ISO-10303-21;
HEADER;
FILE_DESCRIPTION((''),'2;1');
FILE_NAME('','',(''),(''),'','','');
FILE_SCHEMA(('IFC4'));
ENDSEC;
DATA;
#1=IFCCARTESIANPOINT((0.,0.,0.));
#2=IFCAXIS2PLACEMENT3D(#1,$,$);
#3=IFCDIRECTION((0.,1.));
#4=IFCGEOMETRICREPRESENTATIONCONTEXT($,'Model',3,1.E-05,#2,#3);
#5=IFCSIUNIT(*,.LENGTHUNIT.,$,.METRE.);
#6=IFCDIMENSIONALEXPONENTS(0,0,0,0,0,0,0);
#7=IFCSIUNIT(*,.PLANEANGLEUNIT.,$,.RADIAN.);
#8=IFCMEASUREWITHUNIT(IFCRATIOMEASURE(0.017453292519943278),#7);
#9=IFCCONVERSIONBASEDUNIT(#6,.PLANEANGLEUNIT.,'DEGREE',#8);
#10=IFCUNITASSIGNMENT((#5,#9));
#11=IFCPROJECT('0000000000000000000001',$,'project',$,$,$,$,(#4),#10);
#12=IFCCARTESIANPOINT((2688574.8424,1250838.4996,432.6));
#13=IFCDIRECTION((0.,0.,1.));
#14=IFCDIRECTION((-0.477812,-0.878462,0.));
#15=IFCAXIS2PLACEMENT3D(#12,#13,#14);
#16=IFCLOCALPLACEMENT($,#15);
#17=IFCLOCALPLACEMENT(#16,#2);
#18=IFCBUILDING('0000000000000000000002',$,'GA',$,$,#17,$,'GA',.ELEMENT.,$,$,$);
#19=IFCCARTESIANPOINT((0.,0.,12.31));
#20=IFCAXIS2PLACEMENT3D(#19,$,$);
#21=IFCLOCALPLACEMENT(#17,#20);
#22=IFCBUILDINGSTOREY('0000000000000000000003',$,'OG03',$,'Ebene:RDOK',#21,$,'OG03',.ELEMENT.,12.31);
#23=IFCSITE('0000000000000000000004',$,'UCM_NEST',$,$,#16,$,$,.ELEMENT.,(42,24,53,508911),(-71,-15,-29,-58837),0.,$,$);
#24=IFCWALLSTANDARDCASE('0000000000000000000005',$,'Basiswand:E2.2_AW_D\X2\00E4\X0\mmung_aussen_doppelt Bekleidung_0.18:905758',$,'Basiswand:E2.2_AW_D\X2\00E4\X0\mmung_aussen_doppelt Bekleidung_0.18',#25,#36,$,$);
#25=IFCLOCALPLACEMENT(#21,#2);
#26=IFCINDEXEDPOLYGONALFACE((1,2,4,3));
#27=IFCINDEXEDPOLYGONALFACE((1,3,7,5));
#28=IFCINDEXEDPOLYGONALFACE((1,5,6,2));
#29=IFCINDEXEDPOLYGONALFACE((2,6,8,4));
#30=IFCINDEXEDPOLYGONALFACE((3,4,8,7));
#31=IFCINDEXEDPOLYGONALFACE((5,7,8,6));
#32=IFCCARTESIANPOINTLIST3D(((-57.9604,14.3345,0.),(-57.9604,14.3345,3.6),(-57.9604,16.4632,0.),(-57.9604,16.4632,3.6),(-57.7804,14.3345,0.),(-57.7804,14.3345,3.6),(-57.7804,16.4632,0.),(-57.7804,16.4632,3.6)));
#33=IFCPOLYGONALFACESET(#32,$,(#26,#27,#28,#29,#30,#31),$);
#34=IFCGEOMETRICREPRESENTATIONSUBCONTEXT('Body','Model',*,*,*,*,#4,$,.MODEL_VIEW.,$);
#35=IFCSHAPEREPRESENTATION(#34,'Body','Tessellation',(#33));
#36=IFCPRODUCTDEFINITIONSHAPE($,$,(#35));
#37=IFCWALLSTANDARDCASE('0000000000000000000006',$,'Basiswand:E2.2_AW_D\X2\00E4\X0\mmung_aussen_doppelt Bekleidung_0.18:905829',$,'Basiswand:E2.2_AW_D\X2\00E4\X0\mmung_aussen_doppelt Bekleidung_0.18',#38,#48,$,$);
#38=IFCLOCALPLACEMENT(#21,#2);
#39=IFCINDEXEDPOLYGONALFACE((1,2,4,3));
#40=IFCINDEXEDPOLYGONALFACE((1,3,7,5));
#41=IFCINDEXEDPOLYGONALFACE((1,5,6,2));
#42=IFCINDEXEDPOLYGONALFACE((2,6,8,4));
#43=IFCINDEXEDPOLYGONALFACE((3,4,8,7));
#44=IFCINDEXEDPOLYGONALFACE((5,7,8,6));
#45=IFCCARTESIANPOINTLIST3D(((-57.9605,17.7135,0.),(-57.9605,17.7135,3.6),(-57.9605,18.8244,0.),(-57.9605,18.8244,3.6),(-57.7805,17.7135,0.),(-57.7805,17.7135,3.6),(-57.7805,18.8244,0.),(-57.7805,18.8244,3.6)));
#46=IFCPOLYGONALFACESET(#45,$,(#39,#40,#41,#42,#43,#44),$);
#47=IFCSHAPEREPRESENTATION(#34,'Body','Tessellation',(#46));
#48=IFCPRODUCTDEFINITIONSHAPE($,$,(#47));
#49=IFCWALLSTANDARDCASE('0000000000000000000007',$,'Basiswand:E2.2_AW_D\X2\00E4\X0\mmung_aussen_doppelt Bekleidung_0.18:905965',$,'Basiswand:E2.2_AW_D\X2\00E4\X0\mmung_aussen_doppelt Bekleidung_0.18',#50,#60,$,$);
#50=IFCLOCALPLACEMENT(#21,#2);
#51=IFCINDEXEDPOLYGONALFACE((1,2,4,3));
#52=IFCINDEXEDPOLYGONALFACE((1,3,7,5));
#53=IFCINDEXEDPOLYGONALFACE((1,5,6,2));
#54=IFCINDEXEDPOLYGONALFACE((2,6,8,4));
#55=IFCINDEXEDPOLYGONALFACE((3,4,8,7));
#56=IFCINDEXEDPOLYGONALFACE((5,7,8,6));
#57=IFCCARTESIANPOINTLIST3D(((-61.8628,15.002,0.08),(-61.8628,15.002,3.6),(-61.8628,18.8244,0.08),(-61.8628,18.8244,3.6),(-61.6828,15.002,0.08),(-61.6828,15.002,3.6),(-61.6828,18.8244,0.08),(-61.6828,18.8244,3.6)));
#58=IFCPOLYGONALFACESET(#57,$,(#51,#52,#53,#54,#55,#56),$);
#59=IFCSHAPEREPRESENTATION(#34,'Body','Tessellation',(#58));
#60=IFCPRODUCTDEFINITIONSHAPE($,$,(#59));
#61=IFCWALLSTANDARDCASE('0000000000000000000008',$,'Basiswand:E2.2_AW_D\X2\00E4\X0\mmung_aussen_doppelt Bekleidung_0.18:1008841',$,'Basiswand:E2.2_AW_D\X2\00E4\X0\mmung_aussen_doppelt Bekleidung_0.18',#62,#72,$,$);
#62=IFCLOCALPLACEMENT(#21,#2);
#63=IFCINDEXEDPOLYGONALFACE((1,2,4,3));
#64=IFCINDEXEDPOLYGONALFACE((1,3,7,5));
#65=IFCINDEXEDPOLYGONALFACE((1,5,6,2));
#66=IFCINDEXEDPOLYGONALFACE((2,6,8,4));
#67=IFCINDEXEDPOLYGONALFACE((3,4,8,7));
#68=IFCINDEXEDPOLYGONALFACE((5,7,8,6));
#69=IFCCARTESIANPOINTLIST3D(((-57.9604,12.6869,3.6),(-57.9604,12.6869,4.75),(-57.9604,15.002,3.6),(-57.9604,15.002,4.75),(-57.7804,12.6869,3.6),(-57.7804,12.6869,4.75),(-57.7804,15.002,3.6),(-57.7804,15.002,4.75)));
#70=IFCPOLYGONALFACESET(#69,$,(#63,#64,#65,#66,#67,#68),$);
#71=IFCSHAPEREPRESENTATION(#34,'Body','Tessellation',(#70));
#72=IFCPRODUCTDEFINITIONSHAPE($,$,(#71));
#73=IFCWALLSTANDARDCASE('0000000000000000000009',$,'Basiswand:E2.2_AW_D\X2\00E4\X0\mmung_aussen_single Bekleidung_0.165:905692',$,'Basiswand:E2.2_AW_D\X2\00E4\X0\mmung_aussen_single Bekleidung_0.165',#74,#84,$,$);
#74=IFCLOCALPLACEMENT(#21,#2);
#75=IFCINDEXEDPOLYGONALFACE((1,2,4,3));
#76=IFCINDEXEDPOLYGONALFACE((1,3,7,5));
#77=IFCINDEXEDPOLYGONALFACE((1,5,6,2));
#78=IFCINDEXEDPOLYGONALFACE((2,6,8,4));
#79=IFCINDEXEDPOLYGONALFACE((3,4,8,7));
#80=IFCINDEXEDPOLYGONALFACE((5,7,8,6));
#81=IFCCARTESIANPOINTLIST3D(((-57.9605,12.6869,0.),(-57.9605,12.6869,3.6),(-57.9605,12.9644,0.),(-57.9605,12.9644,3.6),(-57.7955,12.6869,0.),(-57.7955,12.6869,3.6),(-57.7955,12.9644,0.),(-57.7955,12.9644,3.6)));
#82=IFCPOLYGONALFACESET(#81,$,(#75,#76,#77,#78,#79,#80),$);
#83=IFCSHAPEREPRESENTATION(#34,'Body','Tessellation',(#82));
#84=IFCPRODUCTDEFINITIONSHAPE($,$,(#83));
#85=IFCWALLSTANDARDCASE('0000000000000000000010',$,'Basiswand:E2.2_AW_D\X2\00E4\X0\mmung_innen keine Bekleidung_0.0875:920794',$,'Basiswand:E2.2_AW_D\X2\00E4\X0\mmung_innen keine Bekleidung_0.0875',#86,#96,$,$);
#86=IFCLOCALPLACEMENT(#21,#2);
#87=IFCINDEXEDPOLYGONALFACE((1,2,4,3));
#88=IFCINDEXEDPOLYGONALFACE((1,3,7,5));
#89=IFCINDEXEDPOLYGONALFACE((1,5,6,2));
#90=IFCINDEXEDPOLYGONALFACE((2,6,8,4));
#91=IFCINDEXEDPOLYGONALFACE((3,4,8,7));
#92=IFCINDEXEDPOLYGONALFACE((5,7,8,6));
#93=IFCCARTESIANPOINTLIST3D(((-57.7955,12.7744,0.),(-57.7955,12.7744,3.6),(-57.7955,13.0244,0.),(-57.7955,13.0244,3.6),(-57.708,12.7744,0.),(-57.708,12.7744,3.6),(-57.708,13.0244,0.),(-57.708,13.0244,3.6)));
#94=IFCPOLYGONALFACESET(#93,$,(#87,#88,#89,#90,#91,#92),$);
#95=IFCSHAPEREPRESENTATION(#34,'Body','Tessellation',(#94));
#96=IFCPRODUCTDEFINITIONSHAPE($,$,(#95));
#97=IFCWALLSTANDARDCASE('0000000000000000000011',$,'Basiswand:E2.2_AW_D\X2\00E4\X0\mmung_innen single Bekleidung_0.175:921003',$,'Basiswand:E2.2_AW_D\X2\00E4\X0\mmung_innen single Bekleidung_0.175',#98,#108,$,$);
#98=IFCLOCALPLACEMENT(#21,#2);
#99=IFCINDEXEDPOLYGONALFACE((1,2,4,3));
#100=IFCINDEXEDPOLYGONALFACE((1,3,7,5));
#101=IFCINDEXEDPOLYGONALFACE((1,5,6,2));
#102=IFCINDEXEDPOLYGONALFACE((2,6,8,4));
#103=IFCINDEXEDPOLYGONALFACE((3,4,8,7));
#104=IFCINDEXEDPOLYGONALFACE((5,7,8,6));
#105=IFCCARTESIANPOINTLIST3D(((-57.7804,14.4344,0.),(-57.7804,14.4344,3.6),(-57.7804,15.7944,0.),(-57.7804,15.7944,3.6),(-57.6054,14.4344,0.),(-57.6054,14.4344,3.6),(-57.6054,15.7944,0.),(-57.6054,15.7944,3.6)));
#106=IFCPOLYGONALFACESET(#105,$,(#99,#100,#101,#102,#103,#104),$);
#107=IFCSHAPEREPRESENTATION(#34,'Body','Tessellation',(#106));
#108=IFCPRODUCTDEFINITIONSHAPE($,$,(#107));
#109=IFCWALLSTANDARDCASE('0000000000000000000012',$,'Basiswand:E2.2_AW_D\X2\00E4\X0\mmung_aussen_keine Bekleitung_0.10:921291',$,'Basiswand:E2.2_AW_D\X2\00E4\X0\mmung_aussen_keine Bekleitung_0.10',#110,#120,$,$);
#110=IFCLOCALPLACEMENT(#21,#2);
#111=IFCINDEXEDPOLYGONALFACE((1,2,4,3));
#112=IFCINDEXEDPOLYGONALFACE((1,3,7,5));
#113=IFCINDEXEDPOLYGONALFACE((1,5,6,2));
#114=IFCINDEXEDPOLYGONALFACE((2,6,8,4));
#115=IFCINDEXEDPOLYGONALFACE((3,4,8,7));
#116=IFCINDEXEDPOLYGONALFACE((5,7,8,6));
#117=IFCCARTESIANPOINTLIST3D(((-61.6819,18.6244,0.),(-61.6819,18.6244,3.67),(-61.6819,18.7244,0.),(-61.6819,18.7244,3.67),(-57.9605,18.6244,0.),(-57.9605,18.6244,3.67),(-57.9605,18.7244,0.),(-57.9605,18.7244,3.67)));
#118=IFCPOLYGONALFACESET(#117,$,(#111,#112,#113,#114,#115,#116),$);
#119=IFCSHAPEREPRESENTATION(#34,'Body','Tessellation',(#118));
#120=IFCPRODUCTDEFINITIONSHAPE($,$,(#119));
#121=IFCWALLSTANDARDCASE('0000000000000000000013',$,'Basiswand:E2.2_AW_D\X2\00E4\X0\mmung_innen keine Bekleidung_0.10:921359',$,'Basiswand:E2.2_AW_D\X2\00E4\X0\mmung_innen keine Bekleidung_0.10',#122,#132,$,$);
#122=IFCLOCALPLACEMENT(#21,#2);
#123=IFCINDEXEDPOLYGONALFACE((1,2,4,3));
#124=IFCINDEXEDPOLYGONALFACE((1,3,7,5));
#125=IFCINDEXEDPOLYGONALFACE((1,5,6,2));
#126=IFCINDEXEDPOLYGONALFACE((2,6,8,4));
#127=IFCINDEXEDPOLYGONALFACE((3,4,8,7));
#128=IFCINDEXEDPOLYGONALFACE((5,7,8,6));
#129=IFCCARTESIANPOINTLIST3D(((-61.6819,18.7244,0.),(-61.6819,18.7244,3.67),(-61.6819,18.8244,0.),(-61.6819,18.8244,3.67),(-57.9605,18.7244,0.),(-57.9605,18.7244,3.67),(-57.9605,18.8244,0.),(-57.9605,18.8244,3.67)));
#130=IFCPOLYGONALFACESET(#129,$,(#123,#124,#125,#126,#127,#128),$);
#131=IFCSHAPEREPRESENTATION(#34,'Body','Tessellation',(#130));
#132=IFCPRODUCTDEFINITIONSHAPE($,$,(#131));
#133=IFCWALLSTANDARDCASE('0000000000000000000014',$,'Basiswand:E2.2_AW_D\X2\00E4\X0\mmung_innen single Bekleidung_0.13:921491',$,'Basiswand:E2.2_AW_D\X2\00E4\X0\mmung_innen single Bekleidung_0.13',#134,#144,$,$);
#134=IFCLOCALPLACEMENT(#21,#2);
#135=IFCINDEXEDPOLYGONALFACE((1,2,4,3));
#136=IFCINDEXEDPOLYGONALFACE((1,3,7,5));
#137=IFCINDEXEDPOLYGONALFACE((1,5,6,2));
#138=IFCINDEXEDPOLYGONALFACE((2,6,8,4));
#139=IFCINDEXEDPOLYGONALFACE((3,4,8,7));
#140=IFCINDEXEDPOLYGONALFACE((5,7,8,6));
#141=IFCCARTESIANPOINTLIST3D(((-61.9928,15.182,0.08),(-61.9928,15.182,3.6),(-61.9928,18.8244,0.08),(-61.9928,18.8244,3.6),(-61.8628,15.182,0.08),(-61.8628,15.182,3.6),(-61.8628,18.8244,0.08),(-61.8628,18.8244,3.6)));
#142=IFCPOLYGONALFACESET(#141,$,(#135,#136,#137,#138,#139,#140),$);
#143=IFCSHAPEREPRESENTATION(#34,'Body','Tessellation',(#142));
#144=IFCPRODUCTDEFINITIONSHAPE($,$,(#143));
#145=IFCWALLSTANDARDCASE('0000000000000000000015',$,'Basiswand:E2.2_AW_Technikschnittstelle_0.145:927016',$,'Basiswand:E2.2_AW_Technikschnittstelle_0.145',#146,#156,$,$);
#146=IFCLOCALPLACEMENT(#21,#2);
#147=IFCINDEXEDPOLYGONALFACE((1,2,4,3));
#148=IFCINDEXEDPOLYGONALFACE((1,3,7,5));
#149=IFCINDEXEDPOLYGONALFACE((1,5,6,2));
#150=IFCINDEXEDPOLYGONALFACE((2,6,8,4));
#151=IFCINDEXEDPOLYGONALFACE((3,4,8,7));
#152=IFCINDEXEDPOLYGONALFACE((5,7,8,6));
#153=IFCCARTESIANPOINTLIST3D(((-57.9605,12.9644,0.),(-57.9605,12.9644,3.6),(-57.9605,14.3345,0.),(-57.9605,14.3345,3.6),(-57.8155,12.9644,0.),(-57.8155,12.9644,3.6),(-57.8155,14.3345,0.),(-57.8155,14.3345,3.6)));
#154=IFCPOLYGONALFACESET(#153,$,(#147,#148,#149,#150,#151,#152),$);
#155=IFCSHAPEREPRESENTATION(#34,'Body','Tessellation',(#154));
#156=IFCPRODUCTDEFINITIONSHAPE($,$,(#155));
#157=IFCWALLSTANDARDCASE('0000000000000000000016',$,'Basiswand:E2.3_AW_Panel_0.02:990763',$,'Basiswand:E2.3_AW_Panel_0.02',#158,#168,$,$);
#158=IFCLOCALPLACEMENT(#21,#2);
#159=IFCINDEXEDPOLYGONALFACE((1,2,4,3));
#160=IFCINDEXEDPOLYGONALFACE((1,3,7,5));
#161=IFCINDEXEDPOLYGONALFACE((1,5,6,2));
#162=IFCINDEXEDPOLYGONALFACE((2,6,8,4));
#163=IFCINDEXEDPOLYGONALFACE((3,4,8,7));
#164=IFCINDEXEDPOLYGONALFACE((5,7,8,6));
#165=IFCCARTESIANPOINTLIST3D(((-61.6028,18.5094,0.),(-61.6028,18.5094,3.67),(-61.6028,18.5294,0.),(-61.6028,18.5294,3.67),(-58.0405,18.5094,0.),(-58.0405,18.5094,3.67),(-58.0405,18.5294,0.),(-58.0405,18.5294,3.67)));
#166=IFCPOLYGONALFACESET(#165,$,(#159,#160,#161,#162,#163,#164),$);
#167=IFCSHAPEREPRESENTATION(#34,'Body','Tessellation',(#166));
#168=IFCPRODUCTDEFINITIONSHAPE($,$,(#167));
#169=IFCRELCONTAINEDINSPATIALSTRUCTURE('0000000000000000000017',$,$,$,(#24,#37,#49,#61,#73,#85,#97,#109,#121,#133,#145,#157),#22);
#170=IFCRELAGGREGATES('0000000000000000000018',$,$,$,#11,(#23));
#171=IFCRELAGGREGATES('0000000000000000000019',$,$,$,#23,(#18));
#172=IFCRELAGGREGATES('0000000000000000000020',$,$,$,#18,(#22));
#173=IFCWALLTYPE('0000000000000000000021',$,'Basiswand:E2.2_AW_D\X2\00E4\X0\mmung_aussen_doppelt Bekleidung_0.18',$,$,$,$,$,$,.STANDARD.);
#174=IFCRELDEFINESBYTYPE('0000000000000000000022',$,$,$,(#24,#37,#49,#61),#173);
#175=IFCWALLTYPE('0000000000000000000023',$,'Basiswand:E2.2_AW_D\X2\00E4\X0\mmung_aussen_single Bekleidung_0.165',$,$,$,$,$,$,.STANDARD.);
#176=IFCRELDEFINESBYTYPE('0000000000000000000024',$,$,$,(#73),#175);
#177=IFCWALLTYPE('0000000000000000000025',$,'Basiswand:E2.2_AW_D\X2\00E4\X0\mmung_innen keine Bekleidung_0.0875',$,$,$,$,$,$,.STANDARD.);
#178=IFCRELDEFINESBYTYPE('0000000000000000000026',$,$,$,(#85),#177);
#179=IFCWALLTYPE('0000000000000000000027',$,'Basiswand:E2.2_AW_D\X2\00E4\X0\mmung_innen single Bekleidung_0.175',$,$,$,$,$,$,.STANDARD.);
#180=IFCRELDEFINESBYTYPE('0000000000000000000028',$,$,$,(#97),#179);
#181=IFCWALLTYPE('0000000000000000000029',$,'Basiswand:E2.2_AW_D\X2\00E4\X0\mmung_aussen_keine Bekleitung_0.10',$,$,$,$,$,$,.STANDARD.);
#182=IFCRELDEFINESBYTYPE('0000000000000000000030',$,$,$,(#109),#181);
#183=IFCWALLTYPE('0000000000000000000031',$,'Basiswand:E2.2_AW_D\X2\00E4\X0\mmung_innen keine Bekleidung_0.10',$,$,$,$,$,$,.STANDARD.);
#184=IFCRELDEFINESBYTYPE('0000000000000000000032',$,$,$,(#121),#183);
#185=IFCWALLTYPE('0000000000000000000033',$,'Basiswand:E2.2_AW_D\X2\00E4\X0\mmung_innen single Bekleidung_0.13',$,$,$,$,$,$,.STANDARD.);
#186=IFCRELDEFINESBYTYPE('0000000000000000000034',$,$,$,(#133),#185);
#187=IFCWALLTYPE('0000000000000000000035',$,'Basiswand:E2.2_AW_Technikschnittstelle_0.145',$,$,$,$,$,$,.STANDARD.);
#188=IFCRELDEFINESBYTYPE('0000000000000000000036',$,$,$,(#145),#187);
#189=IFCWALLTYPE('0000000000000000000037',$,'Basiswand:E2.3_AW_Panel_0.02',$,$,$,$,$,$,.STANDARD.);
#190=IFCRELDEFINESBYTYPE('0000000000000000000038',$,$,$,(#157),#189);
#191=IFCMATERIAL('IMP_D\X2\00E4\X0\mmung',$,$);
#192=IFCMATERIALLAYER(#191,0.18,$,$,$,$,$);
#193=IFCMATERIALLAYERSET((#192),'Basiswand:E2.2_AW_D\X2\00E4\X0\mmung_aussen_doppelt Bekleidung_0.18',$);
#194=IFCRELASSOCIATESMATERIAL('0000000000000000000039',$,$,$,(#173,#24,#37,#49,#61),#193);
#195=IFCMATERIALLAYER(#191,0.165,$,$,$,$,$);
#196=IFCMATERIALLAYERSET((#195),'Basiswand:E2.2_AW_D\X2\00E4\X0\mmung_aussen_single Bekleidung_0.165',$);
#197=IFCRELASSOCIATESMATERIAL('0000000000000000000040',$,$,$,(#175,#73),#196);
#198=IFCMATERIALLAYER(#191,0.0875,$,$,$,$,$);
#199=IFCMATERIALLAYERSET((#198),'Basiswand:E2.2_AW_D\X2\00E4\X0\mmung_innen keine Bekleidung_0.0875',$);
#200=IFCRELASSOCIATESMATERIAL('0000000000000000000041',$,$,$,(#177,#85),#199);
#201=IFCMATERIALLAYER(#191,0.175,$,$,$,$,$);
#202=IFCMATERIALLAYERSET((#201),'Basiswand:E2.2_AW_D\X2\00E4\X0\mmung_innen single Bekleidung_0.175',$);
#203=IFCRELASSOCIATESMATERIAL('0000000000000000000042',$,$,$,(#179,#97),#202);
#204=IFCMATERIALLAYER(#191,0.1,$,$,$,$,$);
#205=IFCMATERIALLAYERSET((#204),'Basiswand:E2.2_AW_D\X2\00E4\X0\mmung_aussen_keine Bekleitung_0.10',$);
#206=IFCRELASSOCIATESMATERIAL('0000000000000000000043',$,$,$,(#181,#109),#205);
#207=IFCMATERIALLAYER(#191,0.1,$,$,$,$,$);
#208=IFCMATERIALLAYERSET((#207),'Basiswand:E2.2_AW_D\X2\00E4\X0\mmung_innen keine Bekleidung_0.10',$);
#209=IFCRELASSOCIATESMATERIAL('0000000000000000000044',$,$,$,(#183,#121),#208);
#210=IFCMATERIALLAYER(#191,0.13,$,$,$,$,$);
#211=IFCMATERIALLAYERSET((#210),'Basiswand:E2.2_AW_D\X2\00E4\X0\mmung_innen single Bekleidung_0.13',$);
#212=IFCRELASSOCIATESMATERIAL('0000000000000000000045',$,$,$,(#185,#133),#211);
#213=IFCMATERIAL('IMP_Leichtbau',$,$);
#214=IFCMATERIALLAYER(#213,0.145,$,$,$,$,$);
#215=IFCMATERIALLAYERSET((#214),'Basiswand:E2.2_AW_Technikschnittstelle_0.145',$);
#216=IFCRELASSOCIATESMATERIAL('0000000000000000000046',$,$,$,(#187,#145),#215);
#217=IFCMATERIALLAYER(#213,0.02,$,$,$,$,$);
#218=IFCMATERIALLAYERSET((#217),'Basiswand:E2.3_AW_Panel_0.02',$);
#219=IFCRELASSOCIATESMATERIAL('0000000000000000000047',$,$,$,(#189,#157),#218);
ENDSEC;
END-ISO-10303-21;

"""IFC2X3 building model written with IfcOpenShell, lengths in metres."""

from ifc_helpers import new_model, entity, si_unit, converted_unit, direction, frame, frame_2d, origin, place, context, subcontext, project, spatial, polyline, rectangle, extrude, clip, bounded_halfspace, material, layer, layer_set, layer_usage, type_object, element, save


model = new_model("IFC2X3")

# Units and contexts
model_context = context("Model", 3, precision=1e-05, world=origin(), true_north=direction((0.0, 1.0)))
body_context = subcontext(model_context, "Body", "Model", "MODEL_VIEW")
ifc_project = project(units=[si_unit("LENGTHUNIT", "METRE"), converted_unit("PLANEANGLEUNIT", "DEGREE", entity("IfcRatioMeasure", 0.017453292519943278), si_unit("PLANEANGLEUNIT", "RADIAN"), dimensions=[0, 0, 0, 0, 0, 0, 0])], contexts=[model_context])

# Site, building, storey
site_placement = place(None, frame((2688574.8424, 1250838.4996, 432.6), z_axis=(0.0, 0.0, 1.0), x_axis=(-0.477812, -0.878462, 0.0)))
site = spatial("IfcSite", under=ifc_project, at=site_placement, Name="UCM_NEST", CompositionType="ELEMENT", RefLatitude=(42, 24, 53, 508911), RefLongitude=(-71, -15, -29, -58837), RefElevation=0.0)
building_placement = place(site_placement, origin())
building = spatial("IfcBuilding", under=site, at=building_placement, Name="GA", LongName="GA", CompositionType="ELEMENT")
storey_placement = place(building_placement, frame((0.0, 0.0, 12.31)))
storey = spatial("IfcBuildingStorey", under=building, at=storey_placement, Name="OG03", ObjectType="Ebene:RDOK", LongName="OG03", CompositionType="ELEMENT", Elevation=12.31)

# Walls
ifc_material_1 = material(Name="IMP_Dämmung")
ifc_layer_1 = layer(ifc_material_1, 0.18)
ifc_layer_set_1 = layer_set([ifc_layer_1], Name="Basiswand:E2.2_AW_Dämmung_aussen_doppelt Bekleidung_0.18")
ifc_layer_usage_1 = layer_usage(ifc_layer_set_1, "AXIS2", "NEGATIVE", 0.09)
wall_type_1 = type_object("IfcWallType", Name="Basiswand:E2.2_AW_Dämmung_aussen_doppelt Bekleidung_0.18", PredefinedType="STANDARD", material=ifc_layer_set_1)
wall_1_placement = place(storey_placement, frame((-57.8704, 14.3345, 0.0), z_axis=(0.0, 0.0, 1.0), x_axis=(0.0, 1.0, 0.0)))
element("IfcWallStandardCase", 1, at=wall_1_placement, inside=storey, type_object=wall_type_1, material=ifc_layer_usage_1, Name="Basiswand:E2.2_AW_Dämmung_aussen_doppelt Bekleidung_0.18:905758", ObjectType="Basiswand:E2.2_AW_Dämmung_aussen_doppelt Bekleidung_0.18", context=body_context, shape_type="SweptSolid", body=[
    extrude(rectangle(XDim=2.1287, YDim=0.18, at=frame_2d((1.0644, 0.0), x_axis=(-1.0, 0.0))), origin(), (0.0, 0.0, 1.0), 3.6),
])
wall_2_placement = place(storey_placement, frame((-57.8705, 17.7135, 0.0), z_axis=(0.0, 0.0, 1.0), x_axis=(0.0, 1.0, 0.0)))
element("IfcWallStandardCase", 2, at=wall_2_placement, inside=storey, type_object=wall_type_1, material=ifc_layer_usage_1, Name="Basiswand:E2.2_AW_Dämmung_aussen_doppelt Bekleidung_0.18:905829", ObjectType="Basiswand:E2.2_AW_Dämmung_aussen_doppelt Bekleidung_0.18", context=body_context, shape_type="SweptSolid", body=[
    extrude(rectangle(XDim=1.111, YDim=0.18, at=frame_2d((0.5555, 0.0), x_axis=(-1.0, 0.0))), origin(), (0.0, 0.0, 1.0), 3.6),
])
wall_3_placement = place(storey_placement, frame((-61.7728, 18.8244, 0.08), z_axis=(0.0, 0.0, 1.0), x_axis=(0.0, -1.0, 0.0)))
element("IfcWallStandardCase", 3, at=wall_3_placement, inside=storey, type_object=wall_type_1, material=ifc_layer_usage_1, Name="Basiswand:E2.2_AW_Dämmung_aussen_doppelt Bekleidung_0.18:905965", ObjectType="Basiswand:E2.2_AW_Dämmung_aussen_doppelt Bekleidung_0.18", context=body_context, shape_type="Clipping", body=[
    clip(extrude(rectangle(XDim=3.8225, YDim=0.18, at=frame_2d((1.9112, 0.0), x_axis=(-1.0, 0.0))), origin(), (0.0, 0.0, 1.0), 3.52), bounded_halfspace(frame((3.8225, -0.09, 0.0), z_axis=(0.0, 0.0, 1.0), x_axis=(0.0, -1.0, 0.0)), True, frame((3.8225, -0.09, 0.0), z_axis=(0.0, 0.0, 1.0), x_axis=(0.0, -1.0, 0.0)), polyline([(0.0, 0.0), (-0.18, 0.0), (-0.18, -3.8225), (0.0, -3.8225), (0.0, -0.18), (0.0, 0.0)]))),
])
wall_4_placement = place(storey_placement, frame((-57.8704, 15.002, 3.6), z_axis=(0.0, 0.0, 1.0), x_axis=(0.0, -1.0, 0.0)))
element("IfcWallStandardCase", 4, at=wall_4_placement, inside=storey, type_object=wall_type_1, material=ifc_layer_usage_1, Name="Basiswand:E2.2_AW_Dämmung_aussen_doppelt Bekleidung_0.18:1008841", ObjectType="Basiswand:E2.2_AW_Dämmung_aussen_doppelt Bekleidung_0.18", context=body_context, shape_type="SweptSolid", body=[
    extrude(rectangle(XDim=2.315, YDim=0.18, at=frame_2d((1.1575, 0.0), x_axis=(-1.0, 0.0))), origin(), (0.0, 0.0, 1.0), 1.15),
])
ifc_layer_2 = layer(ifc_material_1, 0.165)
ifc_layer_set_2 = layer_set([ifc_layer_2], Name="Basiswand:E2.2_AW_Dämmung_aussen_single Bekleidung_0.165")
ifc_layer_usage_2 = layer_usage(ifc_layer_set_2, "AXIS2", "NEGATIVE", 0.0825)
wall_type_2 = type_object("IfcWallType", Name="Basiswand:E2.2_AW_Dämmung_aussen_single Bekleidung_0.165", PredefinedType="STANDARD", material=ifc_layer_set_2)
wall_5_placement = place(storey_placement, frame((-57.878, 12.6869, 0.0), z_axis=(0.0, 0.0, 1.0), x_axis=(0.0, 1.0, 0.0)))
element("IfcWallStandardCase", 5, at=wall_5_placement, inside=storey, type_object=wall_type_2, material=ifc_layer_usage_2, Name="Basiswand:E2.2_AW_Dämmung_aussen_single Bekleidung_0.165:905692", ObjectType="Basiswand:E2.2_AW_Dämmung_aussen_single Bekleidung_0.165", context=body_context, shape_type="SweptSolid", body=[
    extrude(rectangle(XDim=0.2775, YDim=0.165, at=frame_2d((0.1387, 0.0), x_axis=(-1.0, 0.0))), origin(), (0.0, 0.0, 1.0), 3.6),
])
ifc_layer_3 = layer(ifc_material_1, 0.0875)
ifc_layer_set_3 = layer_set([ifc_layer_3], Name="Basiswand:E2.2_AW_Dämmung_innen keine Bekleidung_0.0875")
ifc_layer_usage_3 = layer_usage(ifc_layer_set_3, "AXIS2", "NEGATIVE", 0.0437)
wall_type_3 = type_object("IfcWallType", Name="Basiswand:E2.2_AW_Dämmung_innen keine Bekleidung_0.0875", PredefinedType="STANDARD", material=ifc_layer_set_3)
wall_6_placement = place(storey_placement, frame((-57.7517, 12.7744, 0.0), z_axis=(0.0, 0.0, 1.0), x_axis=(0.0, 1.0, 0.0)))
element("IfcWallStandardCase", 6, at=wall_6_placement, inside=storey, type_object=wall_type_3, material=ifc_layer_usage_3, Name="Basiswand:E2.2_AW_Dämmung_innen keine Bekleidung_0.0875:920794", ObjectType="Basiswand:E2.2_AW_Dämmung_innen keine Bekleidung_0.0875", context=body_context, shape_type="SweptSolid", body=[
    extrude(rectangle(XDim=0.25, YDim=0.0875, at=frame_2d((0.125, 0.0), x_axis=(-1.0, 0.0))), origin(), (0.0, 0.0, 1.0), 3.6),
])
ifc_layer_4 = layer(ifc_material_1, 0.175)
ifc_layer_set_4 = layer_set([ifc_layer_4], Name="Basiswand:E2.2_AW_Dämmung_innen single Bekleidung_0.175")
ifc_layer_usage_4 = layer_usage(ifc_layer_set_4, "AXIS2", "NEGATIVE", 0.0875)
wall_type_4 = type_object("IfcWallType", Name="Basiswand:E2.2_AW_Dämmung_innen single Bekleidung_0.175", PredefinedType="STANDARD", material=ifc_layer_set_4)
wall_7_placement = place(storey_placement, frame((-57.6929, 14.4344, 0.0), z_axis=(0.0, 0.0, 1.0), x_axis=(0.0, 1.0, 0.0)))
element("IfcWallStandardCase", 7, at=wall_7_placement, inside=storey, type_object=wall_type_4, material=ifc_layer_usage_4, Name="Basiswand:E2.2_AW_Dämmung_innen single Bekleidung_0.175:921003", ObjectType="Basiswand:E2.2_AW_Dämmung_innen single Bekleidung_0.175", context=body_context, shape_type="SweptSolid", body=[
    extrude(rectangle(XDim=1.36, YDim=0.175, at=frame_2d((0.68, 0.0), x_axis=(-1.0, 0.0))), origin(), (0.0, 0.0, 1.0), 3.6),
])
ifc_layer_5 = layer(ifc_material_1, 0.1)
ifc_layer_set_5 = layer_set([ifc_layer_5], Name="Basiswand:E2.2_AW_Dämmung_aussen_keine Bekleitung_0.10")
ifc_layer_usage_5 = layer_usage(ifc_layer_set_5, "AXIS2", "NEGATIVE", 0.05)
wall_type_5 = type_object("IfcWallType", Name="Basiswand:E2.2_AW_Dämmung_aussen_keine Bekleitung_0.10", PredefinedType="STANDARD", material=ifc_layer_set_5)
wall_8_placement = place(storey_placement, frame((-57.9605, 18.6744, 0.0), z_axis=(0.0, 0.0, 1.0), x_axis=(-1.0, 0.0, 0.0)))
element("IfcWallStandardCase", 8, at=wall_8_placement, inside=storey, type_object=wall_type_5, material=ifc_layer_usage_5, Name="Basiswand:E2.2_AW_Dämmung_aussen_keine Bekleitung_0.10:921291", ObjectType="Basiswand:E2.2_AW_Dämmung_aussen_keine Bekleitung_0.10", context=body_context, shape_type="SweptSolid", body=[
    extrude(rectangle(XDim=3.7214, YDim=0.1, at=frame_2d((1.8607, 0.0), x_axis=(-1.0, 0.0))), origin(), (0.0, 0.0, 1.0), 3.67),
])
ifc_layer_6 = layer(ifc_material_1, 0.1)
ifc_layer_set_6 = layer_set([ifc_layer_6], Name="Basiswand:E2.2_AW_Dämmung_innen keine Bekleidung_0.10")
ifc_layer_usage_6 = layer_usage(ifc_layer_set_6, "AXIS2", "NEGATIVE", 0.05)
wall_type_6 = type_object("IfcWallType", Name="Basiswand:E2.2_AW_Dämmung_innen keine Bekleidung_0.10", PredefinedType="STANDARD", material=ifc_layer_set_6)
wall_9_placement = place(storey_placement, frame((-57.9605, 18.7744, 0.0), z_axis=(0.0, 0.0, 1.0), x_axis=(-1.0, 0.0, 0.0)))
element("IfcWallStandardCase", 9, at=wall_9_placement, inside=storey, type_object=wall_type_6, material=ifc_layer_usage_6, Name="Basiswand:E2.2_AW_Dämmung_innen keine Bekleidung_0.10:921359", ObjectType="Basiswand:E2.2_AW_Dämmung_innen keine Bekleidung_0.10", context=body_context, shape_type="SweptSolid", body=[
    extrude(rectangle(XDim=3.7214, YDim=0.1, at=frame_2d((1.8607, 0.0), x_axis=(-1.0, 0.0))), origin(), (0.0, 0.0, 1.0), 3.67),
])
ifc_layer_7 = layer(ifc_material_1, 0.13)
ifc_layer_set_7 = layer_set([ifc_layer_7], Name="Basiswand:E2.2_AW_Dämmung_innen single Bekleidung_0.13")
ifc_layer_usage_7 = layer_usage(ifc_layer_set_7, "AXIS2", "NEGATIVE", 0.065)
wall_type_7 = type_object("IfcWallType", Name="Basiswand:E2.2_AW_Dämmung_innen single Bekleidung_0.13", PredefinedType="STANDARD", material=ifc_layer_set_7)
wall_10_placement = place(storey_placement, frame((-61.9278, 18.8244, 0.08), z_axis=(0.0, 0.0, 1.0), x_axis=(0.0, -1.0, 0.0)))
element("IfcWallStandardCase", 10, at=wall_10_placement, inside=storey, type_object=wall_type_7, material=ifc_layer_usage_7, Name="Basiswand:E2.2_AW_Dämmung_innen single Bekleidung_0.13:921491", ObjectType="Basiswand:E2.2_AW_Dämmung_innen single Bekleidung_0.13", context=body_context, shape_type="Clipping", body=[
    clip(extrude(rectangle(XDim=3.6425, YDim=0.13, at=frame_2d((1.8212, 0.0), x_axis=(-1.0, 0.0))), origin(), (0.0, 0.0, 1.0), 3.52), bounded_halfspace(frame((3.6425, -0.065, 0.0), z_axis=(0.0, 0.0, 1.0), x_axis=(0.0, -1.0, 0.0)), True, frame((3.6425, -0.065, 0.0), z_axis=(0.0, 0.0, 1.0), x_axis=(0.0, -1.0, 0.0)), polyline([(0.0, 0.0), (-0.13, 0.0), (-0.13, -3.6425), (0.0, -3.6425), (0.0, -0.13), (0.0, 0.0)]))),
])
ifc_material_2 = material(Name="IMP_Leichtbau")
ifc_layer_8 = layer(ifc_material_2, 0.145)
ifc_layer_set_8 = layer_set([ifc_layer_8], Name="Basiswand:E2.2_AW_Technikschnittstelle_0.145")
ifc_layer_usage_8 = layer_usage(ifc_layer_set_8, "AXIS2", "NEGATIVE", 0.0725)
wall_type_8 = type_object("IfcWallType", Name="Basiswand:E2.2_AW_Technikschnittstelle_0.145", PredefinedType="STANDARD", material=ifc_layer_set_8)
wall_11_placement = place(storey_placement, frame((-57.888, 12.9644, 0.0), z_axis=(0.0, 0.0, 1.0), x_axis=(0.0, 1.0, 0.0)))
element("IfcWallStandardCase", 11, at=wall_11_placement, inside=storey, type_object=wall_type_8, material=ifc_layer_usage_8, Name="Basiswand:E2.2_AW_Technikschnittstelle_0.145:927016", ObjectType="Basiswand:E2.2_AW_Technikschnittstelle_0.145", context=body_context, shape_type="SweptSolid", body=[
    extrude(rectangle(XDim=1.3701, YDim=0.145, at=frame_2d((0.685, 0.0), x_axis=(-1.0, 0.0))), origin(), (0.0, 0.0, 1.0), 3.6),
])

# Wall
ifc_layer_9 = layer(ifc_material_2, 0.02)
ifc_layer_set_9 = layer_set([ifc_layer_9], Name="Basiswand:E2.3_AW_Panel_0.02")
ifc_layer_usage_9 = layer_usage(ifc_layer_set_9, "AXIS2", "NEGATIVE", 0.01)
wall_type_9 = type_object("IfcWallType", Name="Basiswand:E2.3_AW_Panel_0.02", PredefinedType="STANDARD", material=ifc_layer_set_9)
wall_12_placement = place(storey_placement, frame((-58.0405, 18.5194, 0.0), z_axis=(0.0, 0.0, 1.0), x_axis=(-1.0, 0.0, 0.0)))
element("IfcWallStandardCase", 12, at=wall_12_placement, inside=storey, type_object=wall_type_9, material=ifc_layer_usage_9, Name="Basiswand:E2.3_AW_Panel_0.02:990763", ObjectType="Basiswand:E2.3_AW_Panel_0.02", context=body_context, shape_type="SweptSolid", body=[
    extrude(rectangle(XDim=3.5623, YDim=0.02, at=frame_2d((1.7811, 0.0), x_axis=(-1.0, 0.0))), origin(), (0.0, 0.0, 1.0), 3.67),
])

save(model, "model.ifc")
